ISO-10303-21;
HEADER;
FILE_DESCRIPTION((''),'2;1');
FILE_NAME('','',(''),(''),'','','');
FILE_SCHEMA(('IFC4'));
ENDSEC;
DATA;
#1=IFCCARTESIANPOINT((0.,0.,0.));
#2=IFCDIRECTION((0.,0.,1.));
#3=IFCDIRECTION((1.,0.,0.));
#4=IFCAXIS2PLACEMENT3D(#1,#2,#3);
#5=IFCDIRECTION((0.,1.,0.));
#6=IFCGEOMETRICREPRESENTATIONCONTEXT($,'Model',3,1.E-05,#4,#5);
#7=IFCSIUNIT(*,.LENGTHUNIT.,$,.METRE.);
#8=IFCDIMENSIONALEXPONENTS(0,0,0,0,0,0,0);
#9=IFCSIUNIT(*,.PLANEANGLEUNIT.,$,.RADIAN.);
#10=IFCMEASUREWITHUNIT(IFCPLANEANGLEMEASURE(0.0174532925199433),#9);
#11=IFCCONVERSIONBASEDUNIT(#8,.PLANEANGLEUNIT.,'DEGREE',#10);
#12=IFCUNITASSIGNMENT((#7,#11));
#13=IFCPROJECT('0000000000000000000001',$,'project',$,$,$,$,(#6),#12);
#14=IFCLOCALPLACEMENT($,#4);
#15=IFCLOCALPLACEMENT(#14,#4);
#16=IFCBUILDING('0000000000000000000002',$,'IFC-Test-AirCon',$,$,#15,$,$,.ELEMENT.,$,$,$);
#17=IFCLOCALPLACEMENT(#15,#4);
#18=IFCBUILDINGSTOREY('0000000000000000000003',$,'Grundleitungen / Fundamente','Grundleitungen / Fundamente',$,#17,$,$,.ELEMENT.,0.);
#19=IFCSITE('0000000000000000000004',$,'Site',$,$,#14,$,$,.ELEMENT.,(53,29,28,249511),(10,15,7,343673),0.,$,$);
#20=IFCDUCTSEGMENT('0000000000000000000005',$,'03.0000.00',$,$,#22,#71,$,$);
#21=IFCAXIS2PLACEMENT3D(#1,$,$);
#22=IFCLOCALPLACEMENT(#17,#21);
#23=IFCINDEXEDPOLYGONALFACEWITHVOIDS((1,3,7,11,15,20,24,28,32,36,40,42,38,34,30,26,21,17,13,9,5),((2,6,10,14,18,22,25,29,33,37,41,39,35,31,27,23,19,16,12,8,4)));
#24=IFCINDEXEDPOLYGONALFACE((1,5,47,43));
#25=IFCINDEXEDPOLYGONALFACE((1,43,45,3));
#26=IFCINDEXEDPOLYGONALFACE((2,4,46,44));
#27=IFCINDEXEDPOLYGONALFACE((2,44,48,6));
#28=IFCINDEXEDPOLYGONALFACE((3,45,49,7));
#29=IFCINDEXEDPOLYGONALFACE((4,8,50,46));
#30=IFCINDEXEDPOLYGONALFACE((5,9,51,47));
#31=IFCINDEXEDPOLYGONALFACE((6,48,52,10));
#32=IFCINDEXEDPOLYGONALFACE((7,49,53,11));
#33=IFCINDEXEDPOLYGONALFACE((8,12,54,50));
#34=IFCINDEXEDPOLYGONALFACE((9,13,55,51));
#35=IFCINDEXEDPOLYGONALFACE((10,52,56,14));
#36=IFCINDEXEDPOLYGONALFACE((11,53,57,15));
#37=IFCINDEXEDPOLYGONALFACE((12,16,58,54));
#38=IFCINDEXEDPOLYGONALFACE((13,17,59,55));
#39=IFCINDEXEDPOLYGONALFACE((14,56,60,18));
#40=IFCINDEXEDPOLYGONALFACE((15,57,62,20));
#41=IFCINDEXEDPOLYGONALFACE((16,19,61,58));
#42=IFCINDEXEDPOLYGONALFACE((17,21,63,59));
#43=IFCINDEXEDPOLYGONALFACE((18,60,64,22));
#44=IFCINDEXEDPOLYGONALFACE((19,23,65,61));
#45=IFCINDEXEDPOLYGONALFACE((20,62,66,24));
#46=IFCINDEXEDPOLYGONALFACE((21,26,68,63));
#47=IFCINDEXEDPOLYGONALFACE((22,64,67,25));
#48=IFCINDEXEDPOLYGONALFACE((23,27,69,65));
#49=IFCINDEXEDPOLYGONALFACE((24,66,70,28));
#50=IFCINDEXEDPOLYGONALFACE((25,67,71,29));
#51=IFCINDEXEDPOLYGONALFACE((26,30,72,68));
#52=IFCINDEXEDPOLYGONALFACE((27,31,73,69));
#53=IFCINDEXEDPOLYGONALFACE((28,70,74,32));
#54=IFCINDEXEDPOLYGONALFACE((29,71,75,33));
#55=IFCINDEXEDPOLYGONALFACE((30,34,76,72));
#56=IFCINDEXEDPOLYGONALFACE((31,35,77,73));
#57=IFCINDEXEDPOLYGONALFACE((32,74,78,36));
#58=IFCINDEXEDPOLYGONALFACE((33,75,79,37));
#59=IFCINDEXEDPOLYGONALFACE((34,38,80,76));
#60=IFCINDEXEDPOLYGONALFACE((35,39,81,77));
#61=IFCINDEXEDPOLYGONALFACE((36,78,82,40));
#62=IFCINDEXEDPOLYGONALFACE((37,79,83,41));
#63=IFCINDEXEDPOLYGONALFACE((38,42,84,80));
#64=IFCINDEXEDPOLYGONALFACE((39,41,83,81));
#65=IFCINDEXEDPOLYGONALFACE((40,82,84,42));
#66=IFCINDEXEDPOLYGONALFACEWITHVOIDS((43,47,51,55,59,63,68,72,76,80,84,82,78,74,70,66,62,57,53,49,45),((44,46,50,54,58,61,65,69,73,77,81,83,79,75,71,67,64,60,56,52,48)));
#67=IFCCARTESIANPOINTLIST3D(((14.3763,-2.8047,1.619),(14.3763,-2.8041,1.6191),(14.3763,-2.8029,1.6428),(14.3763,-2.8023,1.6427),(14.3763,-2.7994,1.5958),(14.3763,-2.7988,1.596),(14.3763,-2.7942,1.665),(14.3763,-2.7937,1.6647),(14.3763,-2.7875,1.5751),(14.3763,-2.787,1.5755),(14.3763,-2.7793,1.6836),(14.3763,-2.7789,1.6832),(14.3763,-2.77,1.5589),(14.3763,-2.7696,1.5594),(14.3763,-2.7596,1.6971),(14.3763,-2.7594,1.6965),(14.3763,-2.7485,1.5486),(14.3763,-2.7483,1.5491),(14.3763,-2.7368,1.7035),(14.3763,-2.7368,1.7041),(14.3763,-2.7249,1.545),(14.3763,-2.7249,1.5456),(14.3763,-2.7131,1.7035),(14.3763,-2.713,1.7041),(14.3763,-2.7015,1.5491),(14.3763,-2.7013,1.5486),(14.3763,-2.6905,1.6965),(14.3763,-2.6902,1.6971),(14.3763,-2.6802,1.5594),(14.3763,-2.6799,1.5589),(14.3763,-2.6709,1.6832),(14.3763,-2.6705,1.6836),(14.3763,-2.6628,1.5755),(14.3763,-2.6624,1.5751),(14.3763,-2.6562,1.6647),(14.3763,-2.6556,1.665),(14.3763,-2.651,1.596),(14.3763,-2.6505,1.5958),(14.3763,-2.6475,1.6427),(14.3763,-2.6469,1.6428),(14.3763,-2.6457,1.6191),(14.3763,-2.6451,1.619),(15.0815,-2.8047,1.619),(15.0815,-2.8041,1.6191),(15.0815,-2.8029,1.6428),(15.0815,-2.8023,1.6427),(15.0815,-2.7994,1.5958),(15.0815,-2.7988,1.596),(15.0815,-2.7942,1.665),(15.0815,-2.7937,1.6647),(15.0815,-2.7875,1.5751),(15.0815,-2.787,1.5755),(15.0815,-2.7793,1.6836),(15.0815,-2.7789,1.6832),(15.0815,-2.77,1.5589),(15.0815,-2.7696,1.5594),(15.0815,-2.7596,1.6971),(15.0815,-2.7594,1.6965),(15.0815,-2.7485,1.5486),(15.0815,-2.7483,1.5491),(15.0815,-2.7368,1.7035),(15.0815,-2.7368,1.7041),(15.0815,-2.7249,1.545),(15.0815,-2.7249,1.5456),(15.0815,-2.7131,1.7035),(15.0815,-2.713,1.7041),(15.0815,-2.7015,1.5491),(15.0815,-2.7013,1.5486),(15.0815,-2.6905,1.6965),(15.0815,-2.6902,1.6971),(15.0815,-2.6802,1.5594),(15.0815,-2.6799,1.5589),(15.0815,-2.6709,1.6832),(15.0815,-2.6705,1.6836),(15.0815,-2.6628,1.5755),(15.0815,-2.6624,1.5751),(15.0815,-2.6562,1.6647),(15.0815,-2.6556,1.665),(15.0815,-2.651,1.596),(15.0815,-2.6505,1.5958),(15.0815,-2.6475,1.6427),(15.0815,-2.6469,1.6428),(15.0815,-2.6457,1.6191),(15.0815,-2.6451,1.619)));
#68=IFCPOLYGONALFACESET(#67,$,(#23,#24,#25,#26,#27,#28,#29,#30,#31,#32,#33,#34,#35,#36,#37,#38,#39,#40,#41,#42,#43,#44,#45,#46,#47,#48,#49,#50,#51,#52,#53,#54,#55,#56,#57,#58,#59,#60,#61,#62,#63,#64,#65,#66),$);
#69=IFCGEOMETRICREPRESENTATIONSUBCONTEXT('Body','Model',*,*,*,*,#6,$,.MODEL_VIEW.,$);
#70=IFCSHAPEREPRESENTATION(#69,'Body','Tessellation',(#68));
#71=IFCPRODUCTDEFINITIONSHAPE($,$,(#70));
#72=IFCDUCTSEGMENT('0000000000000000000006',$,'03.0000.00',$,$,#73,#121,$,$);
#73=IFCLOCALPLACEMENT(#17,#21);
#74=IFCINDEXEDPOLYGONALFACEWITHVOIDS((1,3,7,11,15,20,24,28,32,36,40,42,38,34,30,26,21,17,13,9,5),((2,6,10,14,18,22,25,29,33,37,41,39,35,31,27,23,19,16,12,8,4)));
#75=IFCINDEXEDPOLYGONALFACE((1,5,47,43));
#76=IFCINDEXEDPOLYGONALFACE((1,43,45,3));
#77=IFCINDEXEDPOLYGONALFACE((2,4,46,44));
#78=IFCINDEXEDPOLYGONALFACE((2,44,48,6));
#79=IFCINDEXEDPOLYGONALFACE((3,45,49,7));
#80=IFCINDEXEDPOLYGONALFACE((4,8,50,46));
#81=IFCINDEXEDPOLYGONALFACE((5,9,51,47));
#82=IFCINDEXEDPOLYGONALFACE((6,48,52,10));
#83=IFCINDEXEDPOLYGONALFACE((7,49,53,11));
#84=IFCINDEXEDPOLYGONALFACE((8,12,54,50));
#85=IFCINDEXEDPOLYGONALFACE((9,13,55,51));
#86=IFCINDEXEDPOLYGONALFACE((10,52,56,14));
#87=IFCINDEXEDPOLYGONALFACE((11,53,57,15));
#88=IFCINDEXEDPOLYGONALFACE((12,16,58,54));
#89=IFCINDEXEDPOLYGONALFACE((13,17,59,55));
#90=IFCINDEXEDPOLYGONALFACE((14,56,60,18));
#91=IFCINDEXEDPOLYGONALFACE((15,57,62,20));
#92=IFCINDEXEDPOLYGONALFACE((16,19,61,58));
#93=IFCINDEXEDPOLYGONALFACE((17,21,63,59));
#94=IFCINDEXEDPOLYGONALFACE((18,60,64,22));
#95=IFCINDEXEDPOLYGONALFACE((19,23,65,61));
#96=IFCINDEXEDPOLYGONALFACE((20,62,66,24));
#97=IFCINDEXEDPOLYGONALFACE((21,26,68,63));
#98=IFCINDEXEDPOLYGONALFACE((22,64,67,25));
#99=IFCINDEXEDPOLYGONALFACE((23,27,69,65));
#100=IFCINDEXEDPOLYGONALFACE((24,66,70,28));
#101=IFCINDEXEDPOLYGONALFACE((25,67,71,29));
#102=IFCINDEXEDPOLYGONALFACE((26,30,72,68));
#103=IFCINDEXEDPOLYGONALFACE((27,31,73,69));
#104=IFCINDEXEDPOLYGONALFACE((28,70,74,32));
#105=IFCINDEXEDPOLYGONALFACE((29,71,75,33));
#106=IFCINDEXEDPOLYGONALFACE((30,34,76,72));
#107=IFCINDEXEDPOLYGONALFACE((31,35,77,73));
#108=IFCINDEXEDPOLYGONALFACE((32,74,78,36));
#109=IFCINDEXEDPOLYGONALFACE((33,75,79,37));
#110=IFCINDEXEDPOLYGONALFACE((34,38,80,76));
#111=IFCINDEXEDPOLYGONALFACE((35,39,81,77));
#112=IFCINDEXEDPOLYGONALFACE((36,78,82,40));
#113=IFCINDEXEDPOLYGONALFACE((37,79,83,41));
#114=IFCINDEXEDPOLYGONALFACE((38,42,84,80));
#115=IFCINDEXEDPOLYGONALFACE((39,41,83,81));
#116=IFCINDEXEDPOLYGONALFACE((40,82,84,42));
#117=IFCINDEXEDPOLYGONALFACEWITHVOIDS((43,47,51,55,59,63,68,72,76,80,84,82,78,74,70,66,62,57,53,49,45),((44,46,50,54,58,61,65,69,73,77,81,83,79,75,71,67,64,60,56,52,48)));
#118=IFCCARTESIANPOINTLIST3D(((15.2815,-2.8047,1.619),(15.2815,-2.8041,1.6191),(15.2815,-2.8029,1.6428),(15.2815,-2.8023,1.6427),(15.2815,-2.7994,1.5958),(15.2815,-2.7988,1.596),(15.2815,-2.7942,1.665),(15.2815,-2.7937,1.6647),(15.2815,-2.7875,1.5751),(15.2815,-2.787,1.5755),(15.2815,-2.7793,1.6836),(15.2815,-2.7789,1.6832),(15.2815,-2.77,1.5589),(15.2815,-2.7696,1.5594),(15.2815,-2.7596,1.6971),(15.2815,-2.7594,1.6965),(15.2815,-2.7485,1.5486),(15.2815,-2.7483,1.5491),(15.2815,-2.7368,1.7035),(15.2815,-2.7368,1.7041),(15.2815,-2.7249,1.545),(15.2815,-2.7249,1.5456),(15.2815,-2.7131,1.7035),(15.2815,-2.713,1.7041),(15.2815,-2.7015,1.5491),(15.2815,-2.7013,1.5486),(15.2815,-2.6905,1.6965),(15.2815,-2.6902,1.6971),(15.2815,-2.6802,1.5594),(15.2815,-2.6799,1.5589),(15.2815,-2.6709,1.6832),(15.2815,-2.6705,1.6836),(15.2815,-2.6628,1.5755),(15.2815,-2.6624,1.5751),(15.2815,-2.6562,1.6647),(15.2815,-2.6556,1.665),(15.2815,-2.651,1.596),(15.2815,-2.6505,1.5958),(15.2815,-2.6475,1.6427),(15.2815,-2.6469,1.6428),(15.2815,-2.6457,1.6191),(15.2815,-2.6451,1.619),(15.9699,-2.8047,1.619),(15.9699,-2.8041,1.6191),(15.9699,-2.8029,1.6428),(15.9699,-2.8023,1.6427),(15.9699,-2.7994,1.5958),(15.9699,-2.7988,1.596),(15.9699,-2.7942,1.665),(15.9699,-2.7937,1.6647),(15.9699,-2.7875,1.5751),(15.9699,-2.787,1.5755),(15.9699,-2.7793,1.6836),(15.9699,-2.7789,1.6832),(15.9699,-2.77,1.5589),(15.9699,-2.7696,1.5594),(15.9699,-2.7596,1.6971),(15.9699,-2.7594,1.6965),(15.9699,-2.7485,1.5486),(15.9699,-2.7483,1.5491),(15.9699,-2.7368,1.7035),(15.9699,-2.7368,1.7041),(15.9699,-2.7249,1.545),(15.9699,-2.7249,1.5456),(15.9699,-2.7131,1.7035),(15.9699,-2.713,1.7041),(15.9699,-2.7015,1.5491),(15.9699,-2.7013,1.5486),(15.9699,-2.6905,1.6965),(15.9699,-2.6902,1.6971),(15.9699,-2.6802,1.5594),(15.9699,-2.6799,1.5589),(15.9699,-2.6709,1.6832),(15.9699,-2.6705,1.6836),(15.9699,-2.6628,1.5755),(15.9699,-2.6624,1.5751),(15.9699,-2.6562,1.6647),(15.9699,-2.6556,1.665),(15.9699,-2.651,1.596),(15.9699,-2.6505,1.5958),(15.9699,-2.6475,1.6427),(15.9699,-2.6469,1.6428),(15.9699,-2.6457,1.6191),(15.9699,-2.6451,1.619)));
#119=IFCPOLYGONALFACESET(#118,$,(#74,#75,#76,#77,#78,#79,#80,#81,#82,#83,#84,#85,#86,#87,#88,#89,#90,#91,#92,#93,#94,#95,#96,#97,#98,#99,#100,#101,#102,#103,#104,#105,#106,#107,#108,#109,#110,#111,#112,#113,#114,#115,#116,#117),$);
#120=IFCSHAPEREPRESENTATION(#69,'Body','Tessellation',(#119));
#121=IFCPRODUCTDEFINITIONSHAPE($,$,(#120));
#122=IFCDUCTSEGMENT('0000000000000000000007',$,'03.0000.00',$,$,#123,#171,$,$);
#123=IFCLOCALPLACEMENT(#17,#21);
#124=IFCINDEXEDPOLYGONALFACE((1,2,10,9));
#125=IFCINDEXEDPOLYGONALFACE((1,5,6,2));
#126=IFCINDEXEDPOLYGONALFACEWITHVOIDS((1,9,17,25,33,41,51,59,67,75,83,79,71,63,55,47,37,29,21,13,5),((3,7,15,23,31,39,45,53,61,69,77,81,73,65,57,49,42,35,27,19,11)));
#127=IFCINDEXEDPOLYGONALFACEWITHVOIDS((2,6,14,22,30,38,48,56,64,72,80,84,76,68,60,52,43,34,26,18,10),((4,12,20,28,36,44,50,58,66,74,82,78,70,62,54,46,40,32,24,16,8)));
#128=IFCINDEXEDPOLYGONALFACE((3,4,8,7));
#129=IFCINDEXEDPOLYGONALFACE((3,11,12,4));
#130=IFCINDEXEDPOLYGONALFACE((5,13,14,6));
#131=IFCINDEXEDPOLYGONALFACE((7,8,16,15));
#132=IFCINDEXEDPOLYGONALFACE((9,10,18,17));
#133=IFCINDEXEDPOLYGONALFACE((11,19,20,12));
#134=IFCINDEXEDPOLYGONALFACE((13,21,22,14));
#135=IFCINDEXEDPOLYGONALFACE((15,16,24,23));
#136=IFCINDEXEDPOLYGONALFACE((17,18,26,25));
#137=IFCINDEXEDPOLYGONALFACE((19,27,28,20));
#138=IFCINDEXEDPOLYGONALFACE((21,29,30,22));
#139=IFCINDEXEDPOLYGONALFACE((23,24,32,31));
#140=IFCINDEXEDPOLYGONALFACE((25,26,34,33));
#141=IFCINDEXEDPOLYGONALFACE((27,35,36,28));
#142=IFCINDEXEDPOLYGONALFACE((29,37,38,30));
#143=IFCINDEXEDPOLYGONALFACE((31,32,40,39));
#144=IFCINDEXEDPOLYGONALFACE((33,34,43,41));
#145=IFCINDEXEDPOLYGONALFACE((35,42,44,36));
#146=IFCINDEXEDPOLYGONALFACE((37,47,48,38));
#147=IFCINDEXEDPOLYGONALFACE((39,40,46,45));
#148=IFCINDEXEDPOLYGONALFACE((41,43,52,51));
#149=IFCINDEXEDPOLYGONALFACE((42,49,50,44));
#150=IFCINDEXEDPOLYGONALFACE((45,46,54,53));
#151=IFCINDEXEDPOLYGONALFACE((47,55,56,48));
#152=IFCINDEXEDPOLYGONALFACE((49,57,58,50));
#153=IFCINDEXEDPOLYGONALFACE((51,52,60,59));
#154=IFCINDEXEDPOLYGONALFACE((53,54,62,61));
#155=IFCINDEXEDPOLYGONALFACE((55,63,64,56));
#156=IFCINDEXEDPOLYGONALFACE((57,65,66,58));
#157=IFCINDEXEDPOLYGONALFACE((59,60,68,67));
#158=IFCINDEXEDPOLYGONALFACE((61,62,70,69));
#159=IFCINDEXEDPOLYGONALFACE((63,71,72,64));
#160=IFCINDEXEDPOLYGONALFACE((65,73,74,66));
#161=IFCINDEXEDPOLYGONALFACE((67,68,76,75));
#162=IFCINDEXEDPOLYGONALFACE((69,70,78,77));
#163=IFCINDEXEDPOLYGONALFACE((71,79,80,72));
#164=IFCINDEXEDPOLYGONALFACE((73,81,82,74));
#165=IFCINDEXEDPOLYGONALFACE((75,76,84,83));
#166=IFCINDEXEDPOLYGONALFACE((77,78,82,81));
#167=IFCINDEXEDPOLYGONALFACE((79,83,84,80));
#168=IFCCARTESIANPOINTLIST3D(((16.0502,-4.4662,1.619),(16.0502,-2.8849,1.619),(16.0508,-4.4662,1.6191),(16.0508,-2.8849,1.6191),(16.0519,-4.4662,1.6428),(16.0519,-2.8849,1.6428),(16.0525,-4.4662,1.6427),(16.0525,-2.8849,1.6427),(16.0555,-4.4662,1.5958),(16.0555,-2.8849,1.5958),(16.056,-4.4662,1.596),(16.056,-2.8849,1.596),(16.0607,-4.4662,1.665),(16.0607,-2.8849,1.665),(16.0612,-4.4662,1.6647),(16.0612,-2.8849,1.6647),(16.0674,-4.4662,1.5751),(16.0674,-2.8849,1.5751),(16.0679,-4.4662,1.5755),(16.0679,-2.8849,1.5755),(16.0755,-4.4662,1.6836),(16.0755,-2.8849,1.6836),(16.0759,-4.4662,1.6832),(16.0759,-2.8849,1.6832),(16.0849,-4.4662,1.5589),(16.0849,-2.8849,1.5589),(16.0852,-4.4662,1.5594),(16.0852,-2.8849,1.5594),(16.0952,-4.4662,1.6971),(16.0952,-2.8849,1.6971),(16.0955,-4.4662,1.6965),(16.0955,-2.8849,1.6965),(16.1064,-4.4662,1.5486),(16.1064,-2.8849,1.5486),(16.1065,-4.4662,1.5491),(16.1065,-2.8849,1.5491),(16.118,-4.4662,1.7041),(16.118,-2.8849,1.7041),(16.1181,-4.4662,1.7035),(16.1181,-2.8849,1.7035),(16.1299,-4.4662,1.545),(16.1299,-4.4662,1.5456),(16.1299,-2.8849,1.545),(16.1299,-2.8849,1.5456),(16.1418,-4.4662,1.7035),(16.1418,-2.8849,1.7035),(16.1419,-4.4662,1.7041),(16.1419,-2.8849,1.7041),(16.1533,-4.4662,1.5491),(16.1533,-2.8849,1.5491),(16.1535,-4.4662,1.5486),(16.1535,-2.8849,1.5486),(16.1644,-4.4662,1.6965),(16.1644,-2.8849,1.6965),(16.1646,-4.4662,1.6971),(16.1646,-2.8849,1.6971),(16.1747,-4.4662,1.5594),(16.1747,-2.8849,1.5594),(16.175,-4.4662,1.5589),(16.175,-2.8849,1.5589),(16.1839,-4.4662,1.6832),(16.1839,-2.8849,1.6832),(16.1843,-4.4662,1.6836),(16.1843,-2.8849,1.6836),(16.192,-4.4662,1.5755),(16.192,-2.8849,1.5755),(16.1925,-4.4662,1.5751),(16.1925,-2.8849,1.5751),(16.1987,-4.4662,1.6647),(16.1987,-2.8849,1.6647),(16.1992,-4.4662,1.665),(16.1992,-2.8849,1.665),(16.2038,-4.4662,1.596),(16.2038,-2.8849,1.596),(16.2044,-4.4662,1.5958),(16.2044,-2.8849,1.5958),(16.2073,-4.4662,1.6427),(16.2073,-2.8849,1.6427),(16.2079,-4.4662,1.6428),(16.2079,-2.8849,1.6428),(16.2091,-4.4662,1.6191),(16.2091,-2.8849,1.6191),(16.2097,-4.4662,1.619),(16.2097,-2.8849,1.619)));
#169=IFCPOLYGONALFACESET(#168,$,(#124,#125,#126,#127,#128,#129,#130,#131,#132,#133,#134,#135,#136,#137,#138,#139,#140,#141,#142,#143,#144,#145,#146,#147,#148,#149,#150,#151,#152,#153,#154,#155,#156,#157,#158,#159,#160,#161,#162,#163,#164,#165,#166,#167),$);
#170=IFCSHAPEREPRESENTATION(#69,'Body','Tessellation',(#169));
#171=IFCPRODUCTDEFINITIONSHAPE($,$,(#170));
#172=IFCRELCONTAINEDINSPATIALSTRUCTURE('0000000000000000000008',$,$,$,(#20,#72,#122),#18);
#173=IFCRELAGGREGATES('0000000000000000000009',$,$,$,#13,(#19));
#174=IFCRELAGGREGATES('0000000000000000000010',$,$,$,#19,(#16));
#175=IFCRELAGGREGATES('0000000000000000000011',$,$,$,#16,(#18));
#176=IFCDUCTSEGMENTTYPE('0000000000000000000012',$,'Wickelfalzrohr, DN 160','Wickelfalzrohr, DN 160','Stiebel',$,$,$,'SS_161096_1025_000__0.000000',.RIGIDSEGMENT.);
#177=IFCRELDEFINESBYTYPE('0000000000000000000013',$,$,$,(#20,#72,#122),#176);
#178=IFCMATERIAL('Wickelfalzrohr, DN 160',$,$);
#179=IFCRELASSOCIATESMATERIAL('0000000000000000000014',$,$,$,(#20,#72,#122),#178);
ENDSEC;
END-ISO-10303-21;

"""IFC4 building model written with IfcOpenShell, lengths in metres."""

from ifc_helpers import new_model, entity, si_unit, converted_unit, direction, frame, origin_with_axes, origin_2d_with_axis, place, context, subcontext, project, spatial, hollow_circle, extrude, material, type_object, element, save


model = new_model("IFC4")

# Units and contexts
model_context = context("Model", 3, precision=1e-05, world=origin_with_axes(), true_north=direction((0.0, 1.0, 0.0)))
body_context = subcontext(model_context, "Body", "Model", "MODEL_VIEW")
ifc_project = project(units=[si_unit("LENGTHUNIT", "METRE"), converted_unit("PLANEANGLEUNIT", "DEGREE", entity("IfcPlaneAngleMeasure", 0.0174532925199433), si_unit("PLANEANGLEUNIT", "RADIAN"), dimensions=[0, 0, 0, 0, 0, 0, 0])], contexts=[model_context])

# Site, building, storey
site_placement = place(None, origin_with_axes())
site = spatial("IfcSite", under=ifc_project, at=site_placement, Name="Site", CompositionType="ELEMENT", RefLatitude=(53, 29, 28, 249511), RefLongitude=(10, 15, 7, 343673), RefElevation=0.0)
building_placement = place(site_placement, origin_with_axes())
building = spatial("IfcBuilding", under=site, at=building_placement, Name="IFC-Test-AirCon", CompositionType="ELEMENT")
storey_placement = place(building_placement, origin_with_axes())
storey = spatial("IfcBuildingStorey", under=building, at=storey_placement, Name="Grundleitungen / Fundamente", Description="Grundleitungen / Fundamente", CompositionType="ELEMENT", Elevation=0.0)

# Duct segments
ifc_material_1 = material(Name="Wickelfalzrohr, DN 160")
duct_segment_type_1 = type_object("IfcDuctSegmentType", Name="Wickelfalzrohr, DN 160", Description="Wickelfalzrohr, DN 160", ApplicableOccurrence="Stiebel", ElementType="SS_161096_1025_000__0.000000", PredefinedType="RIGIDSEGMENT")
duct_segment_1_placement = place(storey_placement, frame((14.3763, -2.7249, 1.625), z_axis=(0.0, 0.0, 1.0), x_axis=(1.0, 0.0, 0.0)))
element("IfcDuctSegment", 1, at=duct_segment_1_placement, inside=storey, type_object=duct_segment_type_1, material=ifc_material_1, Name="03.0000.00", context=body_context, shape_type="SweptSolid", body=[
    extrude(hollow_circle(Radius=0.08, WallThickness=0.0006, at=origin_2d_with_axis()), frame((0.0, 0.0, 0.0), z_axis=(1.0, 0.0, 0.0), x_axis=(0.0, 0.0, -1.0)), (0.0, 0.0, 1.0), 0.7052),
])
duct_segment_2_placement = place(storey_placement, frame((15.2815, -2.7249, 1.625), z_axis=(0.0, 0.0, 1.0), x_axis=(1.0, 0.0, 0.0)))
element("IfcDuctSegment", 2, at=duct_segment_2_placement, inside=storey, type_object=duct_segment_type_1, material=ifc_material_1, Name="03.0000.00", context=body_context, shape_type="SweptSolid", body=[
    extrude(hollow_circle(Radius=0.08, WallThickness=0.0006, at=origin_2d_with_axis()), frame((0.0, 0.0, 0.0), z_axis=(1.0, 0.0, 0.0), x_axis=(0.0, 0.0, -1.0)), (0.0, 0.0, 1.0), 0.6884),
])
duct_segment_3_placement = place(storey_placement, frame((16.1299, -2.8849, 1.625), z_axis=(0.0, 0.0, 1.0), x_axis=(0.0, -1.0, 0.0)))
element("IfcDuctSegment", 3, at=duct_segment_3_placement, inside=storey, type_object=duct_segment_type_1, material=ifc_material_1, Name="03.0000.00", context=body_context, shape_type="SweptSolid", body=[
    extrude(hollow_circle(Radius=0.08, WallThickness=0.0006, at=origin_2d_with_axis()), frame((0.0, 0.0, 0.0), z_axis=(1.0, 0.0, 0.0), x_axis=(0.0, 0.0, -1.0)), (0.0, 0.0, 1.0), 1.5813),
])

save(model, "model.ifc")
